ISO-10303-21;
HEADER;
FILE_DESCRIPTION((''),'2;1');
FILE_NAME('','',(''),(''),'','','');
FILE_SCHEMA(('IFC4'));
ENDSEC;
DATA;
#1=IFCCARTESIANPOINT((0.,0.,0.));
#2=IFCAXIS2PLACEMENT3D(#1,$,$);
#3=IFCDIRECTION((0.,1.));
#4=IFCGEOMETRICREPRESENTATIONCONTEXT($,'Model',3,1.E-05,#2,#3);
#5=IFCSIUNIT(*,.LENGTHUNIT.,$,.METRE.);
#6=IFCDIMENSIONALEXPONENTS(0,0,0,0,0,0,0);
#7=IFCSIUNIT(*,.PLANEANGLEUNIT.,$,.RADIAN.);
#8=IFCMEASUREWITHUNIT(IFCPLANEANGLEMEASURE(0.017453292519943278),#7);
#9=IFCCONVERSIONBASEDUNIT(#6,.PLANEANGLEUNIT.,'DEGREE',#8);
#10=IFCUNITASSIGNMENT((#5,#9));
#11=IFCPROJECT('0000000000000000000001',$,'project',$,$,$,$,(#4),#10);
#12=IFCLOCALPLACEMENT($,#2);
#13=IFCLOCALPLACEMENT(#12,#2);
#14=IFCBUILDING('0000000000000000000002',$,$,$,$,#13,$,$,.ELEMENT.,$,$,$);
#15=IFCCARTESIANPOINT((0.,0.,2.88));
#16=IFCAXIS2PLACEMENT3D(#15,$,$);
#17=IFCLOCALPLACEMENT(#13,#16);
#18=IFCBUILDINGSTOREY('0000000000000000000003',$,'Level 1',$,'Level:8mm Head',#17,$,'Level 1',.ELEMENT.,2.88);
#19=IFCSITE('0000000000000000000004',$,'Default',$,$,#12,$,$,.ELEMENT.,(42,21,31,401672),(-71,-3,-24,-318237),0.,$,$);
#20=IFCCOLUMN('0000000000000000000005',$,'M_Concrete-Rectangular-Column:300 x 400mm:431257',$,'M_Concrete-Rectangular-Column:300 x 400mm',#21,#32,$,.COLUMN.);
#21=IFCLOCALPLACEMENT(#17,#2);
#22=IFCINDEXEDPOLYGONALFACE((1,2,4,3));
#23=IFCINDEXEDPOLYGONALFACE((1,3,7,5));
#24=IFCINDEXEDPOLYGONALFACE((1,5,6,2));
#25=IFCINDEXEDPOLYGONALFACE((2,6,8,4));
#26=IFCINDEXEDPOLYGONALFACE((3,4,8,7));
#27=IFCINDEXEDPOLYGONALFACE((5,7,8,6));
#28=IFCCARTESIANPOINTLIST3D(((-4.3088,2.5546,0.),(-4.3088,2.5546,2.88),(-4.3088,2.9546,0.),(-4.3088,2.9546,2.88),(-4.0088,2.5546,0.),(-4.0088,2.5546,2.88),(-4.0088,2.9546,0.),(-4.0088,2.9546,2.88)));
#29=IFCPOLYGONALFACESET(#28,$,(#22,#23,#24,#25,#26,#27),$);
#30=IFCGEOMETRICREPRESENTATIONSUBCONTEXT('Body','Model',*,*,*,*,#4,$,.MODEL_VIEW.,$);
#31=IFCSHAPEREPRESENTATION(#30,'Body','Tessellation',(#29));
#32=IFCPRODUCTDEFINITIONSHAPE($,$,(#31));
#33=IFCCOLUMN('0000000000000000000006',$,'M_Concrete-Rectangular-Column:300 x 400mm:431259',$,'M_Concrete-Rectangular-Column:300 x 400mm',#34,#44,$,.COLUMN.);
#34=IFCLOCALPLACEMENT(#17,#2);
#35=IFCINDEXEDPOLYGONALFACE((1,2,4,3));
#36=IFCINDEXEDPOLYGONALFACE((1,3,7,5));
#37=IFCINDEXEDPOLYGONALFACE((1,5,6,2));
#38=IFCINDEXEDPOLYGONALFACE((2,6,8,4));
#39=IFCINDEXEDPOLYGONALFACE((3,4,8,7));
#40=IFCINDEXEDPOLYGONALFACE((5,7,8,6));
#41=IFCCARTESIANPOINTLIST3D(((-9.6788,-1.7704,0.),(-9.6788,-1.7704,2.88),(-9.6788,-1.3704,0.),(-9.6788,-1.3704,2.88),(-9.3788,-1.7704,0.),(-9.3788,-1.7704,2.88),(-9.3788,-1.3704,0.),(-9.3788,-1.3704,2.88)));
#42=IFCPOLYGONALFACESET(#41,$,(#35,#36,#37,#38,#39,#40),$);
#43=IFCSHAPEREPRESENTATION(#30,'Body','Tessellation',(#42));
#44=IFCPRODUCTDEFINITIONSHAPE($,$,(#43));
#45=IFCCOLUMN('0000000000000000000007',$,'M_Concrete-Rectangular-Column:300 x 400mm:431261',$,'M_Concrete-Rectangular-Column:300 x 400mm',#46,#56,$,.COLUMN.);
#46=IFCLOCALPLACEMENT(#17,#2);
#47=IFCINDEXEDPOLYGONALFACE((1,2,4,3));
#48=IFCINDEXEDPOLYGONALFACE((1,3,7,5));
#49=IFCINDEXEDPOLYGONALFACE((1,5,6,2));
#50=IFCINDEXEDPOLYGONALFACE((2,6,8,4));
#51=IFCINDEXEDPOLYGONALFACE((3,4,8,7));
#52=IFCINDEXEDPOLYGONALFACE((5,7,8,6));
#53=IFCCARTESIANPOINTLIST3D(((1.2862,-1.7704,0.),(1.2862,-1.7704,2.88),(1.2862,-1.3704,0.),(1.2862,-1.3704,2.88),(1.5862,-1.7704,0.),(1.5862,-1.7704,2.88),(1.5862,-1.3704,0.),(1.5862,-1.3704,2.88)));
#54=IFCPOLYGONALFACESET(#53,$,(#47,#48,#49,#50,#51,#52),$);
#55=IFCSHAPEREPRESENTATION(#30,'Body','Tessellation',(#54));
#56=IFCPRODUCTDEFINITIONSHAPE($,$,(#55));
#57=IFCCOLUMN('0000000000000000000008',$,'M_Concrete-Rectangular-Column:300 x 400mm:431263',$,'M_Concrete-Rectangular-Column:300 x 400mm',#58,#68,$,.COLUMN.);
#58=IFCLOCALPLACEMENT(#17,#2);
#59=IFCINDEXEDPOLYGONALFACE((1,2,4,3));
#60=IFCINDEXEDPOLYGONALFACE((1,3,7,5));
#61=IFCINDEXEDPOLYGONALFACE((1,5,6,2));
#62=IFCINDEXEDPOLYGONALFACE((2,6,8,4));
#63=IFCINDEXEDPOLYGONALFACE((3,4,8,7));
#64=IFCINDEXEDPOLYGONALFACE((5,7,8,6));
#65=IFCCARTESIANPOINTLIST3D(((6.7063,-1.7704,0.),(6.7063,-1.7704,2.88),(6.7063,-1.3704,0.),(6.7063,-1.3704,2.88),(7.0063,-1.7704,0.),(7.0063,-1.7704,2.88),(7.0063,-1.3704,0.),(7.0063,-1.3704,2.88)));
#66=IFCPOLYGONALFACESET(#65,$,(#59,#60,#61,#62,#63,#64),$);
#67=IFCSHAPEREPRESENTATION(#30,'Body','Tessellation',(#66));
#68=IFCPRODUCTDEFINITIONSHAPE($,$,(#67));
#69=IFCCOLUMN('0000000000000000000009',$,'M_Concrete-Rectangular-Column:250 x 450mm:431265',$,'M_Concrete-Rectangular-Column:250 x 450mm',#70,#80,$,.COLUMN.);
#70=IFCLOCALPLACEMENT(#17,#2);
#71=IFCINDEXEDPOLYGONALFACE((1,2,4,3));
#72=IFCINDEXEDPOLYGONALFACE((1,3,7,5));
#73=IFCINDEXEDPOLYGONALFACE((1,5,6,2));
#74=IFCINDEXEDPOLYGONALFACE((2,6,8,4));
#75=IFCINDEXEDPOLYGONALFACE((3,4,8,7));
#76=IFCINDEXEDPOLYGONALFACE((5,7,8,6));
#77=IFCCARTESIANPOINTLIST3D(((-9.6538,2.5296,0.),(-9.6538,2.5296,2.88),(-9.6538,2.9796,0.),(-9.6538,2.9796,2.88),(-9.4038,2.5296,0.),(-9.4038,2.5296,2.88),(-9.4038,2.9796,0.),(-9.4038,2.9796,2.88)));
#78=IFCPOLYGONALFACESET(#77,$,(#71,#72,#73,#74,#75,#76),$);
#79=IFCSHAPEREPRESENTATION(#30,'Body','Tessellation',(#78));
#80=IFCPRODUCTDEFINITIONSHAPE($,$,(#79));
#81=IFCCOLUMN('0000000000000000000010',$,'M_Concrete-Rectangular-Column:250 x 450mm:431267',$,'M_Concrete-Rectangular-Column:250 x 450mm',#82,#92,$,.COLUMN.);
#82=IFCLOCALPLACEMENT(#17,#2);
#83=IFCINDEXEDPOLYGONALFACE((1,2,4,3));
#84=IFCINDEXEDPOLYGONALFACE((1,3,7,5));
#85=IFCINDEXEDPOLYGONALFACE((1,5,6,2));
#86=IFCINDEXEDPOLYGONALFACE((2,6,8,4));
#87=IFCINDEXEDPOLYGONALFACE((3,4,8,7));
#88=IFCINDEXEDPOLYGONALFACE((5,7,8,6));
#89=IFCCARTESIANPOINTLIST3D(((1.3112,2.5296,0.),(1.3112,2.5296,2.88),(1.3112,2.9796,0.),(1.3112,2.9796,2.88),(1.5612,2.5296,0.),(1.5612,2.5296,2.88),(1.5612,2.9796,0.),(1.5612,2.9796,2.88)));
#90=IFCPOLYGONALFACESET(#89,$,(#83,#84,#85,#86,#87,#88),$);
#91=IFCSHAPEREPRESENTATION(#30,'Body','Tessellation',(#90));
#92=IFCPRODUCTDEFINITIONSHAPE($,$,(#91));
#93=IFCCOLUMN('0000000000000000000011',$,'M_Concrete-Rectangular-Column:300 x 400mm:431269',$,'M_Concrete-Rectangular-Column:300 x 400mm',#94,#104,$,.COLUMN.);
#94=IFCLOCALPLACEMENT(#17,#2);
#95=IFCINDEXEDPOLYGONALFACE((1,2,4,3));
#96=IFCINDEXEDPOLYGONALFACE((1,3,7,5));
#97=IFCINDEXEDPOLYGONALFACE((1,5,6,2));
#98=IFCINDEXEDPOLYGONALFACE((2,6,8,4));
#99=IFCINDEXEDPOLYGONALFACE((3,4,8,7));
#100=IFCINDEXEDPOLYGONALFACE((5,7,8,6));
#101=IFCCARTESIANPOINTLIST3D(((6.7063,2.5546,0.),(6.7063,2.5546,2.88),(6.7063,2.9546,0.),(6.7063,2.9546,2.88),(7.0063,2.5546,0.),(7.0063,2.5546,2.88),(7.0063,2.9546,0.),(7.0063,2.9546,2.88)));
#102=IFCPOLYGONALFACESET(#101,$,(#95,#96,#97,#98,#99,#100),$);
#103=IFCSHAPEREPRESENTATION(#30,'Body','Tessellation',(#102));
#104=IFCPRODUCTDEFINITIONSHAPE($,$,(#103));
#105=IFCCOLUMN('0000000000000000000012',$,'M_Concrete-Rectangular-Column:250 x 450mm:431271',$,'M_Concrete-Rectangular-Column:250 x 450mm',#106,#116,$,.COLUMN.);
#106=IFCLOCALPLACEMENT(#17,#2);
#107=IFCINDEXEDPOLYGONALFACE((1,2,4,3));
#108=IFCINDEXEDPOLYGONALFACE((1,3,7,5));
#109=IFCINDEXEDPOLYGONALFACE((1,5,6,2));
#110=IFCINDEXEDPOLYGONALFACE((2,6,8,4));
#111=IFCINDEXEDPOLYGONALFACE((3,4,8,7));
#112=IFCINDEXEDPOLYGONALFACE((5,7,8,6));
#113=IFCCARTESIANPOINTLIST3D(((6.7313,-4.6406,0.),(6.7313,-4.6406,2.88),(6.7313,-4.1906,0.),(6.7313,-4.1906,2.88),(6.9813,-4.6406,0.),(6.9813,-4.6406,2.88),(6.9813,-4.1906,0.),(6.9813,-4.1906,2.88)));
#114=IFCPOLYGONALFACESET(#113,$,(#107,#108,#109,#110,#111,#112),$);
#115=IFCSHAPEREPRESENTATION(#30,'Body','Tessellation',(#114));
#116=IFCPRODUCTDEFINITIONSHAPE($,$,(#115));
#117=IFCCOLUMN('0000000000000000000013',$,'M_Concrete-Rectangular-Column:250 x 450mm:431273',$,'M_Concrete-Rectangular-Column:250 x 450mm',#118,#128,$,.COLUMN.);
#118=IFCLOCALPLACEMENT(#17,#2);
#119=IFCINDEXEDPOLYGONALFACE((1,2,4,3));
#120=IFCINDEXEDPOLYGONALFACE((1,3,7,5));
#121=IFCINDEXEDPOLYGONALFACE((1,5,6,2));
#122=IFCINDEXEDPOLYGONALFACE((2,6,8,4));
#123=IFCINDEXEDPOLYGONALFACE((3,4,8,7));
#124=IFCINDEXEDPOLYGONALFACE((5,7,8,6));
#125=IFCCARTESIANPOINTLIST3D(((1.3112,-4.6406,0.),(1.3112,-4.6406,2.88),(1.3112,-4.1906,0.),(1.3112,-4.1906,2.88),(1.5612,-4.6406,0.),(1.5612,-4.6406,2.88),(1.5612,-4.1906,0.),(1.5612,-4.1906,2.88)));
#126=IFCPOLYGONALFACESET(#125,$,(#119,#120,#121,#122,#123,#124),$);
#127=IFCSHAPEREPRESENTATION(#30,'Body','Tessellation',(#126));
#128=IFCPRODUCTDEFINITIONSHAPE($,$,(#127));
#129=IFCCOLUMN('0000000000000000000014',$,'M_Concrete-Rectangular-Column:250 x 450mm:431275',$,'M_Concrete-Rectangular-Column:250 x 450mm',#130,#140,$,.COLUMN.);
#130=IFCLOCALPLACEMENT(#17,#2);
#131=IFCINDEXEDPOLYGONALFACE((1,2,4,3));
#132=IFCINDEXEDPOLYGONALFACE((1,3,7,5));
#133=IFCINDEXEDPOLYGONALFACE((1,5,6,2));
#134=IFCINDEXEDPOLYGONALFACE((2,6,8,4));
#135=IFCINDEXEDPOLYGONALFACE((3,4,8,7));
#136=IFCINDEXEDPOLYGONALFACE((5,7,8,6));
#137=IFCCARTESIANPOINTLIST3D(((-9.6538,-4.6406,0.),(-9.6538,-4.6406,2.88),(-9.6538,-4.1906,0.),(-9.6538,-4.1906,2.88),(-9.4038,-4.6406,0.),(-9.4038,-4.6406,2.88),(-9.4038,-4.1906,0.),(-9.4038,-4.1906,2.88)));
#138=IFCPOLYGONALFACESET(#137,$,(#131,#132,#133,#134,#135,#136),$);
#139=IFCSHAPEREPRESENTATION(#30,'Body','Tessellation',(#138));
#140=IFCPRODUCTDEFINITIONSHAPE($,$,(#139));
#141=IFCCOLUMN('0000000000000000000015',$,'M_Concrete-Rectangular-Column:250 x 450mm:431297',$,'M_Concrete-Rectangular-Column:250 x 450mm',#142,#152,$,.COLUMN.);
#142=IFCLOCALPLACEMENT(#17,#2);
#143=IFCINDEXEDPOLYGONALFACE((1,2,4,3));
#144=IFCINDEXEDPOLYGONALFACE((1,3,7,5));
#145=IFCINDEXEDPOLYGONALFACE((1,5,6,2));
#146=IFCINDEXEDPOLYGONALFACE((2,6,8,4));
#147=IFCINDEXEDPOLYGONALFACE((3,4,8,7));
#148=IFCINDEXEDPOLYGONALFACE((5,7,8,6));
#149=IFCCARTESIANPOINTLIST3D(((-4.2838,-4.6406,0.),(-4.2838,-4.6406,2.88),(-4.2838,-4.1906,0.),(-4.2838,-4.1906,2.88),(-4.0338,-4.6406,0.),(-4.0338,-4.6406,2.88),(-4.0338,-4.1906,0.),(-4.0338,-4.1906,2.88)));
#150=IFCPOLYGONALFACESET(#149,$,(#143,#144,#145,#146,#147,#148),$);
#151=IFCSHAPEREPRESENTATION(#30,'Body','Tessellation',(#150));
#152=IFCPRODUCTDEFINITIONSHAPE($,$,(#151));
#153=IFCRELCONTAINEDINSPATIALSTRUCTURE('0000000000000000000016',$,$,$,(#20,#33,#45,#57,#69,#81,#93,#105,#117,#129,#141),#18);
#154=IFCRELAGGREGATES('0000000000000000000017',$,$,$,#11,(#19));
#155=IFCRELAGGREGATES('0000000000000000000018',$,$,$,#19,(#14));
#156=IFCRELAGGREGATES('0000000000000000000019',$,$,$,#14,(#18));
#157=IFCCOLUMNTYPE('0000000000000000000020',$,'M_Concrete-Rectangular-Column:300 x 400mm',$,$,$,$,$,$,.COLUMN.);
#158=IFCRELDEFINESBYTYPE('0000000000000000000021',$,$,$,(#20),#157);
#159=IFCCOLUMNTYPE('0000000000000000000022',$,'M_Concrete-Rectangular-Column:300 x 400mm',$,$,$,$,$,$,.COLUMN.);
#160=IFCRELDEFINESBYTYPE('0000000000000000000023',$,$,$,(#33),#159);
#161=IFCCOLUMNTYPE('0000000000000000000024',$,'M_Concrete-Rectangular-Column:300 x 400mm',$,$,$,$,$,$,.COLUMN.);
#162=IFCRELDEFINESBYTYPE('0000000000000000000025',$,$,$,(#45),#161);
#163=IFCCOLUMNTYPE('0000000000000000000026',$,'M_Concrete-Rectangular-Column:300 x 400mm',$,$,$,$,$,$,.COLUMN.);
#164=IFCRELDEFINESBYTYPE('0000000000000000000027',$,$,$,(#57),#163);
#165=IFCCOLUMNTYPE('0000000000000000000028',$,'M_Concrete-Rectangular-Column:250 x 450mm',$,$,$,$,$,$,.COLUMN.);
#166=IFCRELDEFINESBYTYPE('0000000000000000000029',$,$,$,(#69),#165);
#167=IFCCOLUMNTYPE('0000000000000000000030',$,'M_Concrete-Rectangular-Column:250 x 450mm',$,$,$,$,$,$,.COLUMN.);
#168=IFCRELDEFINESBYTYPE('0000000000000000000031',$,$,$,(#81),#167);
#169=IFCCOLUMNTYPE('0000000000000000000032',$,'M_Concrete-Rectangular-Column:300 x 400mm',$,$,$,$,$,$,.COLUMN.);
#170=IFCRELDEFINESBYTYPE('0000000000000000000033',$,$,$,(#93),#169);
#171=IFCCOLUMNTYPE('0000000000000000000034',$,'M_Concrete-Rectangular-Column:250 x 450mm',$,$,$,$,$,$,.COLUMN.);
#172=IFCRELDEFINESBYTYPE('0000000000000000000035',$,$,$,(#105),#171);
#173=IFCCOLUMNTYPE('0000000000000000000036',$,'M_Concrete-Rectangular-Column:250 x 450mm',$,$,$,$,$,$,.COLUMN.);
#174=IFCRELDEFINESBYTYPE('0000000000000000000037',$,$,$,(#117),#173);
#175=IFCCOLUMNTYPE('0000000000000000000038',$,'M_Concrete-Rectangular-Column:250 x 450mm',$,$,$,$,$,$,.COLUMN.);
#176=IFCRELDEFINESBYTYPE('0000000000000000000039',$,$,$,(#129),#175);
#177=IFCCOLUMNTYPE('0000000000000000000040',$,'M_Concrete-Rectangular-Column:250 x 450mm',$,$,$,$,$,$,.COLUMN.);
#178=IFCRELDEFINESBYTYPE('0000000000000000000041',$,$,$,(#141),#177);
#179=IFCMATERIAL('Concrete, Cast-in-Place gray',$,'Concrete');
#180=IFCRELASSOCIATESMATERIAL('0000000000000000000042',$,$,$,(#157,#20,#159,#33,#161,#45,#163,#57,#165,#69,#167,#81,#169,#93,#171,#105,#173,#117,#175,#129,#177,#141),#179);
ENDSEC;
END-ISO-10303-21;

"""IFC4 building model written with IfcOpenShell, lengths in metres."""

from ifc_helpers import new_model, entity, si_unit, converted_unit, direction, frame, origin, place, context, subcontext, project, spatial, indexed_curve, outline, extrude, source, transform, mapped, material, type_object, type_shapes, element, save


model = new_model("IFC4")

# Units and contexts
model_context = context("Model", 3, precision=1e-05, world=origin(), true_north=direction((0.0, 1.0)))
body_context = subcontext(model_context, "Body", "Model", "MODEL_VIEW")
ifc_project = project(units=[si_unit("LENGTHUNIT", "METRE"), converted_unit("PLANEANGLEUNIT", "DEGREE", entity("IfcPlaneAngleMeasure", 0.017453292519943278), si_unit("PLANEANGLEUNIT", "RADIAN"), dimensions=[0, 0, 0, 0, 0, 0, 0])], contexts=[model_context])

# Site, building, storey
site_placement = place(None, origin())
site = spatial("IfcSite", under=ifc_project, at=site_placement, Name="Default", CompositionType="ELEMENT", RefLatitude=(42, 21, 31, 401672), RefLongitude=(-71, -3, -24, -318237), RefElevation=0.0)
building_placement = place(site_placement, origin())
building = spatial("IfcBuilding", under=site, at=building_placement, CompositionType="ELEMENT")
storey_placement = place(building_placement, frame((0.0, 0.0, 2.88)))
storey = spatial("IfcBuildingStorey", under=building, at=storey_placement, Name="Level 1", ObjectType="Level:8mm Head", LongName="Level 1", CompositionType="ELEMENT", Elevation=2.88)

# Columns
ifc_material = material(Name="Concrete, Cast-in-Place gray", Category="Concrete")
column_type_1 = type_object("IfcColumnType", Name="M_Concrete-Rectangular-Column:300 x 400mm", PredefinedType="COLUMN", material=ifc_material)
shared_shape_1 = source(origin(), body_context, "Body", "SweptSolid", [
    extrude(outline(indexed_curve([(-0.15, -0.2), (0.15, -0.2), (0.15, 0.2), (-0.15, 0.2), (-0.15, -0.2)], self_intersect=False)), frame((-4.1588, 2.7546, 2.88), z_axis=(0.0, 0.0, 1.0), x_axis=(-1.0, 0.0, 0.0)), (0.0, 0.0, 1.0), 2.88),
])
type_shapes(column_type_1, [shared_shape_1])
column_1_placement = place(storey_placement, frame((0.0, 0.0, -2.88)))
element("IfcColumn", 1, at=column_1_placement, inside=storey, type_object=column_type_1, material=ifc_material, Name="M_Concrete-Rectangular-Column:300 x 400mm:431257", ObjectType="M_Concrete-Rectangular-Column:300 x 400mm", PredefinedType="COLUMN", context=body_context, shape_type="MappedRepresentation", body=[
    mapped(shared_shape_1, transform((0.0, 0.0, 0.0), scale=1.0)),
])
column_type_2 = type_object("IfcColumnType", Name="M_Concrete-Rectangular-Column:300 x 400mm", PredefinedType="COLUMN", material=ifc_material)
shared_shape_2 = source(origin(), body_context, "Body", "SweptSolid", [
    extrude(outline(indexed_curve([(-0.15, -0.2), (0.15, -0.2), (0.15, 0.2), (-0.15, 0.2), (-0.15, -0.2)], self_intersect=False)), frame((-9.5288, -1.5704, 2.88), z_axis=(0.0, 0.0, 1.0), x_axis=(-1.0, 0.0, 0.0)), (0.0, 0.0, 1.0), 2.88),
])
type_shapes(column_type_2, [shared_shape_2])
column_2_placement = place(storey_placement, frame((0.0, 0.0, -2.88)))
element("IfcColumn", 2, at=column_2_placement, inside=storey, type_object=column_type_2, material=ifc_material, Name="M_Concrete-Rectangular-Column:300 x 400mm:431259", ObjectType="M_Concrete-Rectangular-Column:300 x 400mm", PredefinedType="COLUMN", context=body_context, shape_type="MappedRepresentation", body=[
    mapped(shared_shape_2, transform((0.0, 0.0, 0.0), scale=1.0)),
])
column_type_3 = type_object("IfcColumnType", Name="M_Concrete-Rectangular-Column:300 x 400mm", PredefinedType="COLUMN", material=ifc_material)
shared_shape_3 = source(origin(), body_context, "Body", "SweptSolid", [
    extrude(outline(indexed_curve([(-0.15, -0.2), (0.15, -0.2), (0.15, 0.2), (-0.15, 0.2), (-0.15, -0.2)], self_intersect=False)), frame((1.4362, -1.5704, 2.88), z_axis=(0.0, 0.0, 1.0), x_axis=(-1.0, 0.0, 0.0)), (0.0, 0.0, 1.0), 2.88),
])
type_shapes(column_type_3, [shared_shape_3])
column_3_placement = place(storey_placement, frame((0.0, 0.0, -2.88)))
element("IfcColumn", 3, at=column_3_placement, inside=storey, type_object=column_type_3, material=ifc_material, Name="M_Concrete-Rectangular-Column:300 x 400mm:431261", ObjectType="M_Concrete-Rectangular-Column:300 x 400mm", PredefinedType="COLUMN", context=body_context, shape_type="MappedRepresentation", body=[
    mapped(shared_shape_3, transform((0.0, 0.0, 0.0), scale=1.0)),
])
column_type_4 = type_object("IfcColumnType", Name="M_Concrete-Rectangular-Column:300 x 400mm", PredefinedType="COLUMN", material=ifc_material)
shared_shape_4 = source(origin(), body_context, "Body", "SweptSolid", [
    extrude(outline(indexed_curve([(-0.15, -0.2), (0.15, -0.2), (0.15, 0.2), (-0.15, 0.2), (-0.15, -0.2)], self_intersect=False)), frame((6.8563, -1.5704, 2.88), z_axis=(0.0, 0.0, 1.0), x_axis=(-1.0, 0.0, 0.0)), (0.0, 0.0, 1.0), 2.88),
])
type_shapes(column_type_4, [shared_shape_4])
column_4_placement = place(storey_placement, frame((0.0, 0.0, -2.88)))
element("IfcColumn", 4, at=column_4_placement, inside=storey, type_object=column_type_4, material=ifc_material, Name="M_Concrete-Rectangular-Column:300 x 400mm:431263", ObjectType="M_Concrete-Rectangular-Column:300 x 400mm", PredefinedType="COLUMN", context=body_context, shape_type="MappedRepresentation", body=[
    mapped(shared_shape_4, transform((0.0, 0.0, 0.0), scale=1.0)),
])
column_type_5 = type_object("IfcColumnType", Name="M_Concrete-Rectangular-Column:250 x 450mm", PredefinedType="COLUMN", material=ifc_material)
shared_shape_5 = source(origin(), body_context, "Body", "SweptSolid", [
    extrude(outline(indexed_curve([(-0.125, -0.225), (0.125, -0.225), (0.125, 0.225), (-0.125, 0.225), (-0.125, -0.225)], self_intersect=False)), frame((-9.5288, 2.7546, 2.88), z_axis=(0.0, 0.0, 1.0), x_axis=(-1.0, 0.0, 0.0)), (0.0, 0.0, 1.0), 2.88),
])
type_shapes(column_type_5, [shared_shape_5])
column_5_placement = place(storey_placement, frame((0.0, 0.0, -2.88)))
element("IfcColumn", 5, at=column_5_placement, inside=storey, type_object=column_type_5, material=ifc_material, Name="M_Concrete-Rectangular-Column:250 x 450mm:431265", ObjectType="M_Concrete-Rectangular-Column:250 x 450mm", PredefinedType="COLUMN", context=body_context, shape_type="MappedRepresentation", body=[
    mapped(shared_shape_5, transform((0.0, 0.0, 0.0), scale=1.0)),
])
column_type_6 = type_object("IfcColumnType", Name="M_Concrete-Rectangular-Column:250 x 450mm", PredefinedType="COLUMN", material=ifc_material)
shared_shape_6 = source(origin(), body_context, "Body", "SweptSolid", [
    extrude(outline(indexed_curve([(-0.125, -0.225), (0.125, -0.225), (0.125, 0.225), (-0.125, 0.225), (-0.125, -0.225)], self_intersect=False)), frame((1.4362, 2.7546, 2.88), z_axis=(0.0, 0.0, 1.0), x_axis=(-1.0, 0.0, 0.0)), (0.0, 0.0, 1.0), 2.88),
])
type_shapes(column_type_6, [shared_shape_6])
column_6_placement = place(storey_placement, frame((0.0, 0.0, -2.88)))
element("IfcColumn", 6, at=column_6_placement, inside=storey, type_object=column_type_6, material=ifc_material, Name="M_Concrete-Rectangular-Column:250 x 450mm:431267", ObjectType="M_Concrete-Rectangular-Column:250 x 450mm", PredefinedType="COLUMN", context=body_context, shape_type="MappedRepresentation", body=[
    mapped(shared_shape_6, transform((0.0, 0.0, 0.0), scale=1.0)),
])
column_type_7 = type_object("IfcColumnType", Name="M_Concrete-Rectangular-Column:300 x 400mm", PredefinedType="COLUMN", material=ifc_material)
shared_shape_7 = source(origin(), body_context, "Body", "SweptSolid", [
    extrude(outline(indexed_curve([(-0.15, -0.2), (0.15, -0.2), (0.15, 0.2), (-0.15, 0.2), (-0.15, -0.2)], self_intersect=False)), frame((6.8563, 2.7546, 2.88), z_axis=(0.0, 0.0, 1.0), x_axis=(-1.0, 0.0, 0.0)), (0.0, 0.0, 1.0), 2.88),
])
type_shapes(column_type_7, [shared_shape_7])
column_7_placement = place(storey_placement, frame((0.0, 0.0, -2.88)))
element("IfcColumn", 7, at=column_7_placement, inside=storey, type_object=column_type_7, material=ifc_material, Name="M_Concrete-Rectangular-Column:300 x 400mm:431269", ObjectType="M_Concrete-Rectangular-Column:300 x 400mm", PredefinedType="COLUMN", context=body_context, shape_type="MappedRepresentation", body=[
    mapped(shared_shape_7, transform((0.0, 0.0, 0.0), scale=1.0)),
])
column_type_8 = type_object("IfcColumnType", Name="M_Concrete-Rectangular-Column:250 x 450mm", PredefinedType="COLUMN", material=ifc_material)
shared_shape_8 = source(origin(), body_context, "Body", "SweptSolid", [
    extrude(outline(indexed_curve([(-0.125, -0.225), (0.125, -0.225), (0.125, 0.225), (-0.125, 0.225), (-0.125, -0.225)], self_intersect=False)), frame((6.8563, -4.4156, 2.88), z_axis=(0.0, 0.0, 1.0), x_axis=(-1.0, 0.0, 0.0)), (0.0, 0.0, 1.0), 2.88),
])
type_shapes(column_type_8, [shared_shape_8])
column_8_placement = place(storey_placement, frame((0.0, 0.0, -2.88)))
element("IfcColumn", 8, at=column_8_placement, inside=storey, type_object=column_type_8, material=ifc_material, Name="M_Concrete-Rectangular-Column:250 x 450mm:431271", ObjectType="M_Concrete-Rectangular-Column:250 x 450mm", PredefinedType="COLUMN", context=body_context, shape_type="MappedRepresentation", body=[
    mapped(shared_shape_8, transform((0.0, 0.0, 0.0), scale=1.0)),
])
column_type_9 = type_object("IfcColumnType", Name="M_Concrete-Rectangular-Column:250 x 450mm", PredefinedType="COLUMN", material=ifc_material)
shared_shape_9 = source(origin(), body_context, "Body", "SweptSolid", [
    extrude(outline(indexed_curve([(-0.125, -0.225), (0.125, -0.225), (0.125, 0.225), (-0.125, 0.225), (-0.125, -0.225)], self_intersect=False)), frame((1.4362, -4.4156, 2.88), z_axis=(0.0, 0.0, 1.0), x_axis=(-1.0, 0.0, 0.0)), (0.0, 0.0, 1.0), 2.88),
])
type_shapes(column_type_9, [shared_shape_9])
column_9_placement = place(storey_placement, frame((0.0, 0.0, -2.88)))
element("IfcColumn", 9, at=column_9_placement, inside=storey, type_object=column_type_9, material=ifc_material, Name="M_Concrete-Rectangular-Column:250 x 450mm:431273", ObjectType="M_Concrete-Rectangular-Column:250 x 450mm", PredefinedType="COLUMN", context=body_context, shape_type="MappedRepresentation", body=[
    mapped(shared_shape_9, transform((0.0, 0.0, 0.0), scale=1.0)),
])
column_type_10 = type_object("IfcColumnType", Name="M_Concrete-Rectangular-Column:250 x 450mm", PredefinedType="COLUMN", material=ifc_material)
shared_shape_10 = source(origin(), body_context, "Body", "SweptSolid", [
    extrude(outline(indexed_curve([(-0.125, -0.225), (0.125, -0.225), (0.125, 0.225), (-0.125, 0.225), (-0.125, -0.225)], self_intersect=False)), frame((-9.5288, -4.4156, 2.88), z_axis=(0.0, 0.0, 1.0), x_axis=(-1.0, 0.0, 0.0)), (0.0, 0.0, 1.0), 2.88),
])
type_shapes(column_type_10, [shared_shape_10])
column_10_placement = place(storey_placement, frame((0.0, 0.0, -2.88)))
element("IfcColumn", 10, at=column_10_placement, inside=storey, type_object=column_type_10, material=ifc_material, Name="M_Concrete-Rectangular-Column:250 x 450mm:431275", ObjectType="M_Concrete-Rectangular-Column:250 x 450mm", PredefinedType="COLUMN", context=body_context, shape_type="MappedRepresentation", body=[
    mapped(shared_shape_10, transform((0.0, 0.0, 0.0), scale=1.0)),
])
column_type_11 = type_object("IfcColumnType", Name="M_Concrete-Rectangular-Column:250 x 450mm", PredefinedType="COLUMN", material=ifc_material)
shared_shape_11 = source(origin(), body_context, "Body", "SweptSolid", [
    extrude(outline(indexed_curve([(-0.125, -0.225), (0.125, -0.225), (0.125, 0.225), (-0.125, 0.225), (-0.125, -0.225)], self_intersect=False)), frame((-4.1588, -4.4156, 2.88), z_axis=(0.0, 0.0, 1.0), x_axis=(-1.0, 0.0, 0.0)), (0.0, 0.0, 1.0), 2.88),
])
type_shapes(column_type_11, [shared_shape_11])
column_11_placement = place(storey_placement, frame((0.0, 0.0, -2.88)))
element("IfcColumn", 11, at=column_11_placement, inside=storey, type_object=column_type_11, material=ifc_material, Name="M_Concrete-Rectangular-Column:250 x 450mm:431297", ObjectType="M_Concrete-Rectangular-Column:250 x 450mm", PredefinedType="COLUMN", context=body_context, shape_type="MappedRepresentation", body=[
    mapped(shared_shape_11, transform((0.0, 0.0, 0.0), scale=1.0)),
])

save(model, "model.ifc")
